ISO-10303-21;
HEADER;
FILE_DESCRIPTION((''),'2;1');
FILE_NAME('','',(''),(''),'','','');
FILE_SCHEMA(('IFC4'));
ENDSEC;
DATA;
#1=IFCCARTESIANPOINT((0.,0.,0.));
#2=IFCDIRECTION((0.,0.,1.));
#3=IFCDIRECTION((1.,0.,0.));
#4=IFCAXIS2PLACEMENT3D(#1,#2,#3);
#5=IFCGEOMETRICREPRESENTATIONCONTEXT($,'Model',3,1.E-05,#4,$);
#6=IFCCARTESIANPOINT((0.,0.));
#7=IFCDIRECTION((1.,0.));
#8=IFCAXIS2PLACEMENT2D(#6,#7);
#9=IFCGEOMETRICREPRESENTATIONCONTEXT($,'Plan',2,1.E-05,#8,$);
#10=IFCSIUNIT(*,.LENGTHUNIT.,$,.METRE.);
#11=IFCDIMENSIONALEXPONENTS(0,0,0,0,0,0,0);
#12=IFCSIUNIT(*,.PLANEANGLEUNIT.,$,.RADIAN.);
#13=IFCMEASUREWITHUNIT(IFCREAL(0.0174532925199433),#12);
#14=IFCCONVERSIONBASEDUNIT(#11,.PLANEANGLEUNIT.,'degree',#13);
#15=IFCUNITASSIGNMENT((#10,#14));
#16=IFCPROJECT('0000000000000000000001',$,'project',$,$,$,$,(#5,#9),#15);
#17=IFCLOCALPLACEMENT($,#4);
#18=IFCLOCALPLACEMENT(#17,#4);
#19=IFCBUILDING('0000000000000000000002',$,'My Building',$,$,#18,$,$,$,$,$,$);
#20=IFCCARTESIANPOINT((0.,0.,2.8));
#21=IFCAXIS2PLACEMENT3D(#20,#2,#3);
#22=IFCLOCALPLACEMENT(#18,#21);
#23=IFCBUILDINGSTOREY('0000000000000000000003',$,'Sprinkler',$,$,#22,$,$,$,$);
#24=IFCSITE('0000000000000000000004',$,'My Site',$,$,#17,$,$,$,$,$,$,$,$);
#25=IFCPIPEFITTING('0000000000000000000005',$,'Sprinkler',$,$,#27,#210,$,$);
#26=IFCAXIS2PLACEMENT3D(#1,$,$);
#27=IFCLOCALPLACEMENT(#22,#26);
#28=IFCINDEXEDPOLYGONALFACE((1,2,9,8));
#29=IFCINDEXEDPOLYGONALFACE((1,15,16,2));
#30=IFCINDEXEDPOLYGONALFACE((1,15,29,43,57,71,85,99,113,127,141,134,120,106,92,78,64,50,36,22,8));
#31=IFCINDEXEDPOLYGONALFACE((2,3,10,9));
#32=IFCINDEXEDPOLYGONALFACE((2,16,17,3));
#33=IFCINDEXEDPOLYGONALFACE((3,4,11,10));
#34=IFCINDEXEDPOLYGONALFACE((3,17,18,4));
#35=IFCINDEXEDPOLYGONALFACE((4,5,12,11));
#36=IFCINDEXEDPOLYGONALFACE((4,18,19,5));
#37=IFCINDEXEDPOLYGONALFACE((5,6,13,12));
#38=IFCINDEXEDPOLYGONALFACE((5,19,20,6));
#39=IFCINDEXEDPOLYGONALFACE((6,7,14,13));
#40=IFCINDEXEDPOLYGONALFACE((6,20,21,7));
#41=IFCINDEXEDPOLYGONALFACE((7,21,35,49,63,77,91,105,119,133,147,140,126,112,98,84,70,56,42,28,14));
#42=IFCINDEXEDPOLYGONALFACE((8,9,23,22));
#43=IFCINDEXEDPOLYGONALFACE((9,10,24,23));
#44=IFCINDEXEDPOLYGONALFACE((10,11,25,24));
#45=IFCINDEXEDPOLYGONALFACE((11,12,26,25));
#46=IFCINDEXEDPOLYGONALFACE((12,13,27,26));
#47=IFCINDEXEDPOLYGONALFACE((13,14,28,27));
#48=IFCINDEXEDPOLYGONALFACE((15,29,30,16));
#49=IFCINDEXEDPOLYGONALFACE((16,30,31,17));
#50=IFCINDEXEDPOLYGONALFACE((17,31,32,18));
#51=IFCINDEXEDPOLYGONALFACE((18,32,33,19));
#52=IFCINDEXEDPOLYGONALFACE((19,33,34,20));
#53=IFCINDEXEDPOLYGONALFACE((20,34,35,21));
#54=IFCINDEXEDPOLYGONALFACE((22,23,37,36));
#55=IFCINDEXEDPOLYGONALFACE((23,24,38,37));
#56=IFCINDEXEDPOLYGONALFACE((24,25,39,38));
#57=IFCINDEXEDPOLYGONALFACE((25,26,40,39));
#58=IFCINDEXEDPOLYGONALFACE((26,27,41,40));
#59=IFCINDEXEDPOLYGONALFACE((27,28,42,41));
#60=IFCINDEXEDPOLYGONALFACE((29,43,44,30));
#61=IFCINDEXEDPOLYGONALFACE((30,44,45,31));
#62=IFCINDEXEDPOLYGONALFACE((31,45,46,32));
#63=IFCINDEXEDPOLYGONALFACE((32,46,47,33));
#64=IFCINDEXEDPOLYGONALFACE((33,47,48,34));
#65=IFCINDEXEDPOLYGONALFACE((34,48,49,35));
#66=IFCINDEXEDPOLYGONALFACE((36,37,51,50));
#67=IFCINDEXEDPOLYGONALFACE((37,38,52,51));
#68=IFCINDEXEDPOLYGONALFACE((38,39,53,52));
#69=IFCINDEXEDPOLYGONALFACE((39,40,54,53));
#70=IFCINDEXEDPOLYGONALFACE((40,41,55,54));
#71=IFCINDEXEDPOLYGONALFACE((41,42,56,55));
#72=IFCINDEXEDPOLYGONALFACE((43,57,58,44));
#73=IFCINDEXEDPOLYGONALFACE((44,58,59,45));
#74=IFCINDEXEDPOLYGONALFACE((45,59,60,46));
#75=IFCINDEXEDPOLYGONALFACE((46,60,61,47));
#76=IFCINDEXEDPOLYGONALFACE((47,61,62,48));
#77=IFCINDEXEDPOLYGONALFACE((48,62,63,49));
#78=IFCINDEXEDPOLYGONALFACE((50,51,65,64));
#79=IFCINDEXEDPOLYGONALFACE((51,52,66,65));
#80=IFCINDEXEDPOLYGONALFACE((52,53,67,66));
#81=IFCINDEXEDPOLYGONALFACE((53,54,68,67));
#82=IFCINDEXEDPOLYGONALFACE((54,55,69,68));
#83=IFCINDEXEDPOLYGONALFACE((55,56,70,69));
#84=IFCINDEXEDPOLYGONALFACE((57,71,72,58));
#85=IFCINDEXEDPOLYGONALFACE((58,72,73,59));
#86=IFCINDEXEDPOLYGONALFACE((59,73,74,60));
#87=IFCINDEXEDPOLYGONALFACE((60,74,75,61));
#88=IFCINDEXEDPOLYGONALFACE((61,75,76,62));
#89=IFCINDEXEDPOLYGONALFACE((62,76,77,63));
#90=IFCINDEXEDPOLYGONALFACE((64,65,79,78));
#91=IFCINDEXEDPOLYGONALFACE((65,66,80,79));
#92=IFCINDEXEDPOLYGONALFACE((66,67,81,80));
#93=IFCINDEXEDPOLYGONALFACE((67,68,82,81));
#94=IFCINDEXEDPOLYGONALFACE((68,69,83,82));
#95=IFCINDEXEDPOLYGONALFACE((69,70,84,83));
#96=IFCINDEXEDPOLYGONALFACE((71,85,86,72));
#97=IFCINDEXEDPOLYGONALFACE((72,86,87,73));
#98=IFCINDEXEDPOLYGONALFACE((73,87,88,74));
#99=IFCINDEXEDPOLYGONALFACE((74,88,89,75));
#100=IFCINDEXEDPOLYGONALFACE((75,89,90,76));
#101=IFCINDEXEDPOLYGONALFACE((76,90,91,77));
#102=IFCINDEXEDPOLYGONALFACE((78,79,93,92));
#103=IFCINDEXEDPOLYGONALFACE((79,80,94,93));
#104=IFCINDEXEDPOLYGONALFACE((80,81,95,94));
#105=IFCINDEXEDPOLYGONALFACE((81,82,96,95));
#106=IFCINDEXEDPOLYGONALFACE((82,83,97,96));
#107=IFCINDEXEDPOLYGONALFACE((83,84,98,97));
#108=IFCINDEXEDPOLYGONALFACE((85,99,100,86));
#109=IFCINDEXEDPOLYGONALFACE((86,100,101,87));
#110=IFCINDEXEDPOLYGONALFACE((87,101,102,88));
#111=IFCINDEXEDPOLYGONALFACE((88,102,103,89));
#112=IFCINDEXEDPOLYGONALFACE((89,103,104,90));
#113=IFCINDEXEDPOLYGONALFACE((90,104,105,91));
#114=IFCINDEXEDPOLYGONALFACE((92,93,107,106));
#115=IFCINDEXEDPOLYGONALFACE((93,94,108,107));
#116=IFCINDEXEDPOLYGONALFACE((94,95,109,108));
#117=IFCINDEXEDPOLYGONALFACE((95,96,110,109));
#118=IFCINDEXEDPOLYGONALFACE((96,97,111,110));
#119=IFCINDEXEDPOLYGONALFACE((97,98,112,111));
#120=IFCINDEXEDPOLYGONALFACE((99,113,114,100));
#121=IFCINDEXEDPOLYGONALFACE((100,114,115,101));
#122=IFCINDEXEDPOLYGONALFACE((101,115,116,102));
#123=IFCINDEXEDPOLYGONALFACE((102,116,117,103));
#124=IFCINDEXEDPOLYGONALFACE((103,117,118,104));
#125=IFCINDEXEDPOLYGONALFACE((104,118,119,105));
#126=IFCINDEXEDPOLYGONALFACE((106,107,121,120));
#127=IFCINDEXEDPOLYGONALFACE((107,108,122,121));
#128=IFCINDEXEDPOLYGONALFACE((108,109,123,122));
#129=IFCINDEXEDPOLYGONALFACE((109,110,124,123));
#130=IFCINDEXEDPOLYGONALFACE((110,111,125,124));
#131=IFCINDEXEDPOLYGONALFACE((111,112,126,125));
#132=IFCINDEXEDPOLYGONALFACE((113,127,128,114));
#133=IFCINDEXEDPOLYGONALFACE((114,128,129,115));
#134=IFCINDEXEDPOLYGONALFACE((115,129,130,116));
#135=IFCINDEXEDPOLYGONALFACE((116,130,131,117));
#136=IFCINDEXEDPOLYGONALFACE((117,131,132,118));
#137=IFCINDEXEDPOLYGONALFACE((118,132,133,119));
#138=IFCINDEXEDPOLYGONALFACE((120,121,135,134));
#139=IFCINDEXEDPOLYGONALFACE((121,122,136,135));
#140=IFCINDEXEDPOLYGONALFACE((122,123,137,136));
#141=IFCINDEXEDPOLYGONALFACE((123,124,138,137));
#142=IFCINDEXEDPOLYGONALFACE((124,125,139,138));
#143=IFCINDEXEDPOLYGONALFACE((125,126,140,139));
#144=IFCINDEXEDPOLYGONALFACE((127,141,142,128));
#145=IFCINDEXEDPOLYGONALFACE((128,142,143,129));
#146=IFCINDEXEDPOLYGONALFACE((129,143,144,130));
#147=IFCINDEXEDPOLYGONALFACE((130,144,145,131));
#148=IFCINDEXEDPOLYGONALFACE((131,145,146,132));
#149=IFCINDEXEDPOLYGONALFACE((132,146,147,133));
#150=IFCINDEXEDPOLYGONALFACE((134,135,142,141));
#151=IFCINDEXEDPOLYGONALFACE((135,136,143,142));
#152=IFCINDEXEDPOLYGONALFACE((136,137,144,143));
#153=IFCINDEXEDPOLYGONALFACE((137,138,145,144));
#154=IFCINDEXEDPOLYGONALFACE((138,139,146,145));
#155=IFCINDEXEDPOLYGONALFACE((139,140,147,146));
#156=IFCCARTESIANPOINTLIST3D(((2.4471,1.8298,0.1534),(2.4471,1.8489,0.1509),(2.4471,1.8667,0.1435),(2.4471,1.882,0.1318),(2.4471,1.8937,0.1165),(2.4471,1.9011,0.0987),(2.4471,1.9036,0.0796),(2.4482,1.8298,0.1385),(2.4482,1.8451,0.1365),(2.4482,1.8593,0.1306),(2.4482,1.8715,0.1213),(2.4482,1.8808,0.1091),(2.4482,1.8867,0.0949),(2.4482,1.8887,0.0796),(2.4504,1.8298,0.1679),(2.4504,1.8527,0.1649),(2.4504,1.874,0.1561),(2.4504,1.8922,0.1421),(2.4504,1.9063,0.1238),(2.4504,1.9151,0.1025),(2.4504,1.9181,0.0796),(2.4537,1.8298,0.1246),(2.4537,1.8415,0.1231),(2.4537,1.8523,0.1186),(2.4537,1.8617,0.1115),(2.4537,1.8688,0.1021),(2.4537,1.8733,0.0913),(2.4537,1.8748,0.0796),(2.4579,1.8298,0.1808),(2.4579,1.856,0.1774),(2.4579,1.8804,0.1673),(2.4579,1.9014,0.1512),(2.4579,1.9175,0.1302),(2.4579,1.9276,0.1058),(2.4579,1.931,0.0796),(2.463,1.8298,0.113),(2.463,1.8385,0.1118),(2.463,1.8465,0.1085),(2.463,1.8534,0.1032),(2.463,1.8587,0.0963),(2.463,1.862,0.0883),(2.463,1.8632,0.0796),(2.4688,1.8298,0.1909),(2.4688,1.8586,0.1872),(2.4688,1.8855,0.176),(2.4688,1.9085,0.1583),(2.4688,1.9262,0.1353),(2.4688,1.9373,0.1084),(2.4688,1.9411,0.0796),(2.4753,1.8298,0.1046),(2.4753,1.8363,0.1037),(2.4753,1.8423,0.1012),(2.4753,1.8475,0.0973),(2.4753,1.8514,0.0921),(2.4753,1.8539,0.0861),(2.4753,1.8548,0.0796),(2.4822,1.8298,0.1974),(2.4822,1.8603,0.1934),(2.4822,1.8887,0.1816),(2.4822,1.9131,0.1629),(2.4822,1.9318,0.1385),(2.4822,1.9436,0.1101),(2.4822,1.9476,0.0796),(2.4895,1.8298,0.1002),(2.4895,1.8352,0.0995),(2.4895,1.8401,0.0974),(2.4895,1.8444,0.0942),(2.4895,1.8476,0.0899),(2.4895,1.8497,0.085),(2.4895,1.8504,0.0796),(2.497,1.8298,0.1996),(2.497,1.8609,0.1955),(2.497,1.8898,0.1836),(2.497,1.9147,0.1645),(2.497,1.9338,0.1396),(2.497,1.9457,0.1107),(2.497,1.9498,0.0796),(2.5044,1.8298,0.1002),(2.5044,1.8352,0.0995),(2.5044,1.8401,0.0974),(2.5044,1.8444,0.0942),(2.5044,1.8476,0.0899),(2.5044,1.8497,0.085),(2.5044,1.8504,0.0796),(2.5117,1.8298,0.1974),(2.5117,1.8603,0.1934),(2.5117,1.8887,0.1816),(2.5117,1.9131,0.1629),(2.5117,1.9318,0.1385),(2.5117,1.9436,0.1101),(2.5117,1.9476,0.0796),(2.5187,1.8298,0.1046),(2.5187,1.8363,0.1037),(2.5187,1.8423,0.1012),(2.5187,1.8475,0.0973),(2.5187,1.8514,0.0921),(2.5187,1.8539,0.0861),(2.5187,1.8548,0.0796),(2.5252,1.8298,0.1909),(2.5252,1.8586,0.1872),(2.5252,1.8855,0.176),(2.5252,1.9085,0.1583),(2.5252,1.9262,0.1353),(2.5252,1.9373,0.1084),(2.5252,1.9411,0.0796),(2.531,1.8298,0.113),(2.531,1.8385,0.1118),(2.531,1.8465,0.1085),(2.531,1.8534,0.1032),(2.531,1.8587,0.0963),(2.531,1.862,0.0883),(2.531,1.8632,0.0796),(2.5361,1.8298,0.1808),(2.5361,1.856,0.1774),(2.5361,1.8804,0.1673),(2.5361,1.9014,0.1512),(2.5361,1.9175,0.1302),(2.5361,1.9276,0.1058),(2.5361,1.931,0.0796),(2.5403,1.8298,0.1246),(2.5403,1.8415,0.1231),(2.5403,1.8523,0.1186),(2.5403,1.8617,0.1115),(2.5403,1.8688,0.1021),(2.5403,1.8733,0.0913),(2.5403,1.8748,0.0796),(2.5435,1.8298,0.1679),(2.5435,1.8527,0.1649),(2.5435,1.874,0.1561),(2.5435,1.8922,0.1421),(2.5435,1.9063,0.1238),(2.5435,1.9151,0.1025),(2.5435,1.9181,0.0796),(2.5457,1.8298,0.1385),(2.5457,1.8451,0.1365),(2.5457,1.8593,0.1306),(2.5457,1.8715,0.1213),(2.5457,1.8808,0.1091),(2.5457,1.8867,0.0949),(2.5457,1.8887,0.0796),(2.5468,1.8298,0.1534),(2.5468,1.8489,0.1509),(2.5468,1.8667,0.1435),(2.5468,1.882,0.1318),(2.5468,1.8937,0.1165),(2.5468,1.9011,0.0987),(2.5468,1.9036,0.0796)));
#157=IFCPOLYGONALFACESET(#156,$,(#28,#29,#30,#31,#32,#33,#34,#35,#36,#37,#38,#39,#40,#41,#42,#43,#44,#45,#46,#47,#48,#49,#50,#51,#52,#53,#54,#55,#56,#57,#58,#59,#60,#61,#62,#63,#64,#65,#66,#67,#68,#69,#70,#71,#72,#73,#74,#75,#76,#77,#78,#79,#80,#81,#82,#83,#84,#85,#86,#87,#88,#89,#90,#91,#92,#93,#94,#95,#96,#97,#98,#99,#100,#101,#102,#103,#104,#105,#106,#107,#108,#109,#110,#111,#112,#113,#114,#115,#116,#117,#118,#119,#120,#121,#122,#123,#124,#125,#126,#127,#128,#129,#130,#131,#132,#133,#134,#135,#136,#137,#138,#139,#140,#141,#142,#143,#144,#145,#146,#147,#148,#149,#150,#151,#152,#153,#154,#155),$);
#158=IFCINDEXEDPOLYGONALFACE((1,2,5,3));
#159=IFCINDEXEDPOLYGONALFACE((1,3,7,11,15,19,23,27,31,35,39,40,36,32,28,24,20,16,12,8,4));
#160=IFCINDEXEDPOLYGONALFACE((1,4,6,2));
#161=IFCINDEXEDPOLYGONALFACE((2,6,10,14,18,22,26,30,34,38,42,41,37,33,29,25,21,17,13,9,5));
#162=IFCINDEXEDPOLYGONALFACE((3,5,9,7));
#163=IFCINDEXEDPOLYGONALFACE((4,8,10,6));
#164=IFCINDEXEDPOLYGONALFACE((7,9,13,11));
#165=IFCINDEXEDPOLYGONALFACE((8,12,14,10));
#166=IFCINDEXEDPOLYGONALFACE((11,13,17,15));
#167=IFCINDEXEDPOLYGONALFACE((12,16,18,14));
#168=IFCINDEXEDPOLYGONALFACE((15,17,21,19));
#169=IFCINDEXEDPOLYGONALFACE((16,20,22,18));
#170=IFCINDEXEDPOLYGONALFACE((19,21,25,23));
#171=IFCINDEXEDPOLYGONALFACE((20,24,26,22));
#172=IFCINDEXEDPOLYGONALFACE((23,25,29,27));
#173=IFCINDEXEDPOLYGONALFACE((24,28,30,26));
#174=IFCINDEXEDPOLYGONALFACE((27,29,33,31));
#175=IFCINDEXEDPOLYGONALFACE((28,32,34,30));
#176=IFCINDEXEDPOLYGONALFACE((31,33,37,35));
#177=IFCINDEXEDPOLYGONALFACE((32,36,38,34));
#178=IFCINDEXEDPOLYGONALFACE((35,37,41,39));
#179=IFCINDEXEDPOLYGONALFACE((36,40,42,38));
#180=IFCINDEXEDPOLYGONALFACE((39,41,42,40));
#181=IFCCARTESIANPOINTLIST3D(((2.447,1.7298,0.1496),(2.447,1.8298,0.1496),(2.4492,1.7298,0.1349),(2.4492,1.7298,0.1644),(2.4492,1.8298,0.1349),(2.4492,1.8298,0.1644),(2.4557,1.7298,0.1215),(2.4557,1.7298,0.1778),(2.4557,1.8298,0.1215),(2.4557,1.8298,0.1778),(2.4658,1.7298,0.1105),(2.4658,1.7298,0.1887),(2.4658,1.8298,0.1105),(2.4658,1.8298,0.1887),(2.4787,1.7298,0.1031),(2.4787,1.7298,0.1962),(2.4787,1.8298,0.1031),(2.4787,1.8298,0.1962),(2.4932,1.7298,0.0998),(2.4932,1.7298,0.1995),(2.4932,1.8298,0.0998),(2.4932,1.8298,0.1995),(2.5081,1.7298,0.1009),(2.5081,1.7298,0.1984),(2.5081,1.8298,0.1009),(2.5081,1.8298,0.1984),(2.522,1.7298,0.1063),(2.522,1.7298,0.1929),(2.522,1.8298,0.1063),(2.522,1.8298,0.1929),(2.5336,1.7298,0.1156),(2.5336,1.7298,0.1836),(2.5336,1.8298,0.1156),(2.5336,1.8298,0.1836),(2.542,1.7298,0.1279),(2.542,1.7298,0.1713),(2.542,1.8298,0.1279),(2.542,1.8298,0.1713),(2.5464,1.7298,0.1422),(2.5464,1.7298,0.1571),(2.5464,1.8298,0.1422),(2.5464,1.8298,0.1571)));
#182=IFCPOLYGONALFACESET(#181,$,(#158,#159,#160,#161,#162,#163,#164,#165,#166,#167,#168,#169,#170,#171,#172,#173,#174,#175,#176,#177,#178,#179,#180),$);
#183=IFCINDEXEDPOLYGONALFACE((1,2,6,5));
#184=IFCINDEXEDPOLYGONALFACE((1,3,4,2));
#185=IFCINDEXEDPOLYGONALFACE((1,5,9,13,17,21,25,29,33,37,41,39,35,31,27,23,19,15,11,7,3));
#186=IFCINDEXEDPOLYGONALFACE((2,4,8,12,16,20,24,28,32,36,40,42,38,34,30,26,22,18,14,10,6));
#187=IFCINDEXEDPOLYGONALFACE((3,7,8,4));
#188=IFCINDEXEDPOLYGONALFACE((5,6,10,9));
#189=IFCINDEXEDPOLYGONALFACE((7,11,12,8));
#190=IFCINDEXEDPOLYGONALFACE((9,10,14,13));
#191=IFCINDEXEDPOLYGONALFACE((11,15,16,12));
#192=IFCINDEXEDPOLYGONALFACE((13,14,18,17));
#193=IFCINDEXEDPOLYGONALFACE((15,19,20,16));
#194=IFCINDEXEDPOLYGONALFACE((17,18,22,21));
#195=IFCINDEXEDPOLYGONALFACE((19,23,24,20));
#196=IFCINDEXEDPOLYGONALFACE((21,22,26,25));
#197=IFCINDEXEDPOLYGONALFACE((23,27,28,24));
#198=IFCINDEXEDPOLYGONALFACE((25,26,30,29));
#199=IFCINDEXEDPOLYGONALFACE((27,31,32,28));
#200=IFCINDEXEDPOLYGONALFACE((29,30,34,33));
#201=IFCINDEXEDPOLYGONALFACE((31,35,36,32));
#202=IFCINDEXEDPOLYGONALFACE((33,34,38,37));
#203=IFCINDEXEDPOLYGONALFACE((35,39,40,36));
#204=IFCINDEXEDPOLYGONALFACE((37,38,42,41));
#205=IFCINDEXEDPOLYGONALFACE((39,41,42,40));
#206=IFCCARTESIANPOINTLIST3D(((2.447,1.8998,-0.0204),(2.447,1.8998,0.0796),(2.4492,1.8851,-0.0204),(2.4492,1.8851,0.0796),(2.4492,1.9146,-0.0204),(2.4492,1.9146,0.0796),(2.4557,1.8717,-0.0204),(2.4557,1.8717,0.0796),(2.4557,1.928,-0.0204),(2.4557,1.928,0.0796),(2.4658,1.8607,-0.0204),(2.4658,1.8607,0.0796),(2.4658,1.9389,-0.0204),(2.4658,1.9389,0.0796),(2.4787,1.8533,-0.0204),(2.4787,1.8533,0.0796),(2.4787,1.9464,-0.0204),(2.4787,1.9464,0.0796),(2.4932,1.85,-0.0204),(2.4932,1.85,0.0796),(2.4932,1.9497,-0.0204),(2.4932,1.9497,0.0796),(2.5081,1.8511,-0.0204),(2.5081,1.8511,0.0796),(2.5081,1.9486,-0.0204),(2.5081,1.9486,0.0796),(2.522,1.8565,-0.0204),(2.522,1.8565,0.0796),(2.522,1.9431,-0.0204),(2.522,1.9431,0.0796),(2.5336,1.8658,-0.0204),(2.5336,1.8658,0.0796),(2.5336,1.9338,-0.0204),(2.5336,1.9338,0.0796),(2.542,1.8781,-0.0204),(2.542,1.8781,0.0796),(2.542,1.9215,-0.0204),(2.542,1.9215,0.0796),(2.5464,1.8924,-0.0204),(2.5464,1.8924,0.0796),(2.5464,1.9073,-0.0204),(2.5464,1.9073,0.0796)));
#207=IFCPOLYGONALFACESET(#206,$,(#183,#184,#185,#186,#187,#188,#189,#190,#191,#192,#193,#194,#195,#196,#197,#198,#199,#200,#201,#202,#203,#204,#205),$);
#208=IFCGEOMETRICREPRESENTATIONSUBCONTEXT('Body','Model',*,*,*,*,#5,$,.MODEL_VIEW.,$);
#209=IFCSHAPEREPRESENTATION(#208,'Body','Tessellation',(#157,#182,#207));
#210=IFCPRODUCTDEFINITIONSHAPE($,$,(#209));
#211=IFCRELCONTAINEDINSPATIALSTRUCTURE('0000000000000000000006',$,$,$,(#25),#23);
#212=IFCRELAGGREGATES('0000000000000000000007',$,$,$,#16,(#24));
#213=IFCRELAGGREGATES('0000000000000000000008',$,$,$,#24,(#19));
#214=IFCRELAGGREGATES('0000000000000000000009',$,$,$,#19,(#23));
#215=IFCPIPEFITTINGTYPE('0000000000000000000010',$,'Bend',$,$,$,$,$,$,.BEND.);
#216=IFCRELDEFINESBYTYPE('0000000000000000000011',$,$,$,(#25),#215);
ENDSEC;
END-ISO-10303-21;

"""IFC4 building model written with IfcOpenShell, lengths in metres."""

from ifc_helpers import new_model, entity, si_unit, converted_unit, frame, origin_with_axes, origin_2d_with_axis, place, context, subcontext, project, spatial, circle, extrude, source, transform, mapped, type_object, type_shapes, element, save


model = new_model("IFC4")

# Units and contexts
model_context = context("Model", 3, precision=1e-05, world=origin_with_axes())
plan_context = context("Plan", 2, precision=1e-05, world=origin_2d_with_axis())
body_context = subcontext(model_context, "Body", "Model", "MODEL_VIEW")
ifc_project = project(units=[si_unit("LENGTHUNIT", "METRE"), converted_unit("PLANEANGLEUNIT", "degree", entity("IfcReal", 0.0174532925199433), si_unit("PLANEANGLEUNIT", "RADIAN"), dimensions=[0, 0, 0, 0, 0, 0, 0])], contexts=[model_context, plan_context])

# Site, building, storey
site_placement = place(None, origin_with_axes())
site = spatial("IfcSite", under=ifc_project, at=site_placement, Name="My Site")
building_placement = place(site_placement, origin_with_axes())
building = spatial("IfcBuilding", under=site, at=building_placement, Name="My Building")
storey_placement = place(building_placement, frame((0.0, 0.0, 2.8), z_axis=(0.0, 0.0, 1.0), x_axis=(1.0, 0.0, 0.0)))
storey = spatial("IfcBuildingStorey", under=building, at=storey_placement, Name="Sprinkler")

# Pipe fitting
pipe_fitting_type_1 = type_object("IfcPipeFittingType", Name="Bend", PredefinedType="BEND")
shared_shape_1 = source(origin_with_axes(), body_context, "Body", "SolidModel", [
    entity("IfcSweptDiskSolid", entity("IfcIndexedPolyCurve", entity("IfcCartesianPointList3D", [[0.0, 0.0, 0.1], [0.0, -0.0205, 0.1495], [0.0, -0.07, 0.17]]), [entity("IfcArcIndex", [1, 2, 3])]), 0.05),
    extrude(circle(Radius=0.05), origin_with_axes(), (0.0, 0.0, 1.0), 0.1),
    extrude(circle(Radius=0.05), frame((0.0, -0.07, 0.17), z_axis=(0.0, -1.0, 0.0), x_axis=(1.0, 0.0, 0.0)), (0.0, 0.0, 1.0), 0.1),
])
type_shapes(pipe_fitting_type_1, [shared_shape_1])
for number, where, z_axis, x_axis, name in (
    (1, (2.497, 1.7298, 0.1496), (-0.000001, 1.0, 0.0), (-1.0, -0.000001, 0.0), "Sprinkler"),
):
    element("IfcPipeFitting", number, at=place(storey_placement, frame(where, z_axis=z_axis, x_axis=x_axis)), inside=storey, type_object=pipe_fitting_type_1, Name=name, context=body_context, shape_type="MappedRepresentation", body=[
        mapped(shared_shape_1, transform((0.0, 0.0, 0.0), x_axis=(1.0, 0.0, 0.0), y_axis=(0.0, 1.0, 0.0), z_axis=(0.0, 0.0, 1.0), scale=1.0)),
    ])

save(model, "model.ifc")
